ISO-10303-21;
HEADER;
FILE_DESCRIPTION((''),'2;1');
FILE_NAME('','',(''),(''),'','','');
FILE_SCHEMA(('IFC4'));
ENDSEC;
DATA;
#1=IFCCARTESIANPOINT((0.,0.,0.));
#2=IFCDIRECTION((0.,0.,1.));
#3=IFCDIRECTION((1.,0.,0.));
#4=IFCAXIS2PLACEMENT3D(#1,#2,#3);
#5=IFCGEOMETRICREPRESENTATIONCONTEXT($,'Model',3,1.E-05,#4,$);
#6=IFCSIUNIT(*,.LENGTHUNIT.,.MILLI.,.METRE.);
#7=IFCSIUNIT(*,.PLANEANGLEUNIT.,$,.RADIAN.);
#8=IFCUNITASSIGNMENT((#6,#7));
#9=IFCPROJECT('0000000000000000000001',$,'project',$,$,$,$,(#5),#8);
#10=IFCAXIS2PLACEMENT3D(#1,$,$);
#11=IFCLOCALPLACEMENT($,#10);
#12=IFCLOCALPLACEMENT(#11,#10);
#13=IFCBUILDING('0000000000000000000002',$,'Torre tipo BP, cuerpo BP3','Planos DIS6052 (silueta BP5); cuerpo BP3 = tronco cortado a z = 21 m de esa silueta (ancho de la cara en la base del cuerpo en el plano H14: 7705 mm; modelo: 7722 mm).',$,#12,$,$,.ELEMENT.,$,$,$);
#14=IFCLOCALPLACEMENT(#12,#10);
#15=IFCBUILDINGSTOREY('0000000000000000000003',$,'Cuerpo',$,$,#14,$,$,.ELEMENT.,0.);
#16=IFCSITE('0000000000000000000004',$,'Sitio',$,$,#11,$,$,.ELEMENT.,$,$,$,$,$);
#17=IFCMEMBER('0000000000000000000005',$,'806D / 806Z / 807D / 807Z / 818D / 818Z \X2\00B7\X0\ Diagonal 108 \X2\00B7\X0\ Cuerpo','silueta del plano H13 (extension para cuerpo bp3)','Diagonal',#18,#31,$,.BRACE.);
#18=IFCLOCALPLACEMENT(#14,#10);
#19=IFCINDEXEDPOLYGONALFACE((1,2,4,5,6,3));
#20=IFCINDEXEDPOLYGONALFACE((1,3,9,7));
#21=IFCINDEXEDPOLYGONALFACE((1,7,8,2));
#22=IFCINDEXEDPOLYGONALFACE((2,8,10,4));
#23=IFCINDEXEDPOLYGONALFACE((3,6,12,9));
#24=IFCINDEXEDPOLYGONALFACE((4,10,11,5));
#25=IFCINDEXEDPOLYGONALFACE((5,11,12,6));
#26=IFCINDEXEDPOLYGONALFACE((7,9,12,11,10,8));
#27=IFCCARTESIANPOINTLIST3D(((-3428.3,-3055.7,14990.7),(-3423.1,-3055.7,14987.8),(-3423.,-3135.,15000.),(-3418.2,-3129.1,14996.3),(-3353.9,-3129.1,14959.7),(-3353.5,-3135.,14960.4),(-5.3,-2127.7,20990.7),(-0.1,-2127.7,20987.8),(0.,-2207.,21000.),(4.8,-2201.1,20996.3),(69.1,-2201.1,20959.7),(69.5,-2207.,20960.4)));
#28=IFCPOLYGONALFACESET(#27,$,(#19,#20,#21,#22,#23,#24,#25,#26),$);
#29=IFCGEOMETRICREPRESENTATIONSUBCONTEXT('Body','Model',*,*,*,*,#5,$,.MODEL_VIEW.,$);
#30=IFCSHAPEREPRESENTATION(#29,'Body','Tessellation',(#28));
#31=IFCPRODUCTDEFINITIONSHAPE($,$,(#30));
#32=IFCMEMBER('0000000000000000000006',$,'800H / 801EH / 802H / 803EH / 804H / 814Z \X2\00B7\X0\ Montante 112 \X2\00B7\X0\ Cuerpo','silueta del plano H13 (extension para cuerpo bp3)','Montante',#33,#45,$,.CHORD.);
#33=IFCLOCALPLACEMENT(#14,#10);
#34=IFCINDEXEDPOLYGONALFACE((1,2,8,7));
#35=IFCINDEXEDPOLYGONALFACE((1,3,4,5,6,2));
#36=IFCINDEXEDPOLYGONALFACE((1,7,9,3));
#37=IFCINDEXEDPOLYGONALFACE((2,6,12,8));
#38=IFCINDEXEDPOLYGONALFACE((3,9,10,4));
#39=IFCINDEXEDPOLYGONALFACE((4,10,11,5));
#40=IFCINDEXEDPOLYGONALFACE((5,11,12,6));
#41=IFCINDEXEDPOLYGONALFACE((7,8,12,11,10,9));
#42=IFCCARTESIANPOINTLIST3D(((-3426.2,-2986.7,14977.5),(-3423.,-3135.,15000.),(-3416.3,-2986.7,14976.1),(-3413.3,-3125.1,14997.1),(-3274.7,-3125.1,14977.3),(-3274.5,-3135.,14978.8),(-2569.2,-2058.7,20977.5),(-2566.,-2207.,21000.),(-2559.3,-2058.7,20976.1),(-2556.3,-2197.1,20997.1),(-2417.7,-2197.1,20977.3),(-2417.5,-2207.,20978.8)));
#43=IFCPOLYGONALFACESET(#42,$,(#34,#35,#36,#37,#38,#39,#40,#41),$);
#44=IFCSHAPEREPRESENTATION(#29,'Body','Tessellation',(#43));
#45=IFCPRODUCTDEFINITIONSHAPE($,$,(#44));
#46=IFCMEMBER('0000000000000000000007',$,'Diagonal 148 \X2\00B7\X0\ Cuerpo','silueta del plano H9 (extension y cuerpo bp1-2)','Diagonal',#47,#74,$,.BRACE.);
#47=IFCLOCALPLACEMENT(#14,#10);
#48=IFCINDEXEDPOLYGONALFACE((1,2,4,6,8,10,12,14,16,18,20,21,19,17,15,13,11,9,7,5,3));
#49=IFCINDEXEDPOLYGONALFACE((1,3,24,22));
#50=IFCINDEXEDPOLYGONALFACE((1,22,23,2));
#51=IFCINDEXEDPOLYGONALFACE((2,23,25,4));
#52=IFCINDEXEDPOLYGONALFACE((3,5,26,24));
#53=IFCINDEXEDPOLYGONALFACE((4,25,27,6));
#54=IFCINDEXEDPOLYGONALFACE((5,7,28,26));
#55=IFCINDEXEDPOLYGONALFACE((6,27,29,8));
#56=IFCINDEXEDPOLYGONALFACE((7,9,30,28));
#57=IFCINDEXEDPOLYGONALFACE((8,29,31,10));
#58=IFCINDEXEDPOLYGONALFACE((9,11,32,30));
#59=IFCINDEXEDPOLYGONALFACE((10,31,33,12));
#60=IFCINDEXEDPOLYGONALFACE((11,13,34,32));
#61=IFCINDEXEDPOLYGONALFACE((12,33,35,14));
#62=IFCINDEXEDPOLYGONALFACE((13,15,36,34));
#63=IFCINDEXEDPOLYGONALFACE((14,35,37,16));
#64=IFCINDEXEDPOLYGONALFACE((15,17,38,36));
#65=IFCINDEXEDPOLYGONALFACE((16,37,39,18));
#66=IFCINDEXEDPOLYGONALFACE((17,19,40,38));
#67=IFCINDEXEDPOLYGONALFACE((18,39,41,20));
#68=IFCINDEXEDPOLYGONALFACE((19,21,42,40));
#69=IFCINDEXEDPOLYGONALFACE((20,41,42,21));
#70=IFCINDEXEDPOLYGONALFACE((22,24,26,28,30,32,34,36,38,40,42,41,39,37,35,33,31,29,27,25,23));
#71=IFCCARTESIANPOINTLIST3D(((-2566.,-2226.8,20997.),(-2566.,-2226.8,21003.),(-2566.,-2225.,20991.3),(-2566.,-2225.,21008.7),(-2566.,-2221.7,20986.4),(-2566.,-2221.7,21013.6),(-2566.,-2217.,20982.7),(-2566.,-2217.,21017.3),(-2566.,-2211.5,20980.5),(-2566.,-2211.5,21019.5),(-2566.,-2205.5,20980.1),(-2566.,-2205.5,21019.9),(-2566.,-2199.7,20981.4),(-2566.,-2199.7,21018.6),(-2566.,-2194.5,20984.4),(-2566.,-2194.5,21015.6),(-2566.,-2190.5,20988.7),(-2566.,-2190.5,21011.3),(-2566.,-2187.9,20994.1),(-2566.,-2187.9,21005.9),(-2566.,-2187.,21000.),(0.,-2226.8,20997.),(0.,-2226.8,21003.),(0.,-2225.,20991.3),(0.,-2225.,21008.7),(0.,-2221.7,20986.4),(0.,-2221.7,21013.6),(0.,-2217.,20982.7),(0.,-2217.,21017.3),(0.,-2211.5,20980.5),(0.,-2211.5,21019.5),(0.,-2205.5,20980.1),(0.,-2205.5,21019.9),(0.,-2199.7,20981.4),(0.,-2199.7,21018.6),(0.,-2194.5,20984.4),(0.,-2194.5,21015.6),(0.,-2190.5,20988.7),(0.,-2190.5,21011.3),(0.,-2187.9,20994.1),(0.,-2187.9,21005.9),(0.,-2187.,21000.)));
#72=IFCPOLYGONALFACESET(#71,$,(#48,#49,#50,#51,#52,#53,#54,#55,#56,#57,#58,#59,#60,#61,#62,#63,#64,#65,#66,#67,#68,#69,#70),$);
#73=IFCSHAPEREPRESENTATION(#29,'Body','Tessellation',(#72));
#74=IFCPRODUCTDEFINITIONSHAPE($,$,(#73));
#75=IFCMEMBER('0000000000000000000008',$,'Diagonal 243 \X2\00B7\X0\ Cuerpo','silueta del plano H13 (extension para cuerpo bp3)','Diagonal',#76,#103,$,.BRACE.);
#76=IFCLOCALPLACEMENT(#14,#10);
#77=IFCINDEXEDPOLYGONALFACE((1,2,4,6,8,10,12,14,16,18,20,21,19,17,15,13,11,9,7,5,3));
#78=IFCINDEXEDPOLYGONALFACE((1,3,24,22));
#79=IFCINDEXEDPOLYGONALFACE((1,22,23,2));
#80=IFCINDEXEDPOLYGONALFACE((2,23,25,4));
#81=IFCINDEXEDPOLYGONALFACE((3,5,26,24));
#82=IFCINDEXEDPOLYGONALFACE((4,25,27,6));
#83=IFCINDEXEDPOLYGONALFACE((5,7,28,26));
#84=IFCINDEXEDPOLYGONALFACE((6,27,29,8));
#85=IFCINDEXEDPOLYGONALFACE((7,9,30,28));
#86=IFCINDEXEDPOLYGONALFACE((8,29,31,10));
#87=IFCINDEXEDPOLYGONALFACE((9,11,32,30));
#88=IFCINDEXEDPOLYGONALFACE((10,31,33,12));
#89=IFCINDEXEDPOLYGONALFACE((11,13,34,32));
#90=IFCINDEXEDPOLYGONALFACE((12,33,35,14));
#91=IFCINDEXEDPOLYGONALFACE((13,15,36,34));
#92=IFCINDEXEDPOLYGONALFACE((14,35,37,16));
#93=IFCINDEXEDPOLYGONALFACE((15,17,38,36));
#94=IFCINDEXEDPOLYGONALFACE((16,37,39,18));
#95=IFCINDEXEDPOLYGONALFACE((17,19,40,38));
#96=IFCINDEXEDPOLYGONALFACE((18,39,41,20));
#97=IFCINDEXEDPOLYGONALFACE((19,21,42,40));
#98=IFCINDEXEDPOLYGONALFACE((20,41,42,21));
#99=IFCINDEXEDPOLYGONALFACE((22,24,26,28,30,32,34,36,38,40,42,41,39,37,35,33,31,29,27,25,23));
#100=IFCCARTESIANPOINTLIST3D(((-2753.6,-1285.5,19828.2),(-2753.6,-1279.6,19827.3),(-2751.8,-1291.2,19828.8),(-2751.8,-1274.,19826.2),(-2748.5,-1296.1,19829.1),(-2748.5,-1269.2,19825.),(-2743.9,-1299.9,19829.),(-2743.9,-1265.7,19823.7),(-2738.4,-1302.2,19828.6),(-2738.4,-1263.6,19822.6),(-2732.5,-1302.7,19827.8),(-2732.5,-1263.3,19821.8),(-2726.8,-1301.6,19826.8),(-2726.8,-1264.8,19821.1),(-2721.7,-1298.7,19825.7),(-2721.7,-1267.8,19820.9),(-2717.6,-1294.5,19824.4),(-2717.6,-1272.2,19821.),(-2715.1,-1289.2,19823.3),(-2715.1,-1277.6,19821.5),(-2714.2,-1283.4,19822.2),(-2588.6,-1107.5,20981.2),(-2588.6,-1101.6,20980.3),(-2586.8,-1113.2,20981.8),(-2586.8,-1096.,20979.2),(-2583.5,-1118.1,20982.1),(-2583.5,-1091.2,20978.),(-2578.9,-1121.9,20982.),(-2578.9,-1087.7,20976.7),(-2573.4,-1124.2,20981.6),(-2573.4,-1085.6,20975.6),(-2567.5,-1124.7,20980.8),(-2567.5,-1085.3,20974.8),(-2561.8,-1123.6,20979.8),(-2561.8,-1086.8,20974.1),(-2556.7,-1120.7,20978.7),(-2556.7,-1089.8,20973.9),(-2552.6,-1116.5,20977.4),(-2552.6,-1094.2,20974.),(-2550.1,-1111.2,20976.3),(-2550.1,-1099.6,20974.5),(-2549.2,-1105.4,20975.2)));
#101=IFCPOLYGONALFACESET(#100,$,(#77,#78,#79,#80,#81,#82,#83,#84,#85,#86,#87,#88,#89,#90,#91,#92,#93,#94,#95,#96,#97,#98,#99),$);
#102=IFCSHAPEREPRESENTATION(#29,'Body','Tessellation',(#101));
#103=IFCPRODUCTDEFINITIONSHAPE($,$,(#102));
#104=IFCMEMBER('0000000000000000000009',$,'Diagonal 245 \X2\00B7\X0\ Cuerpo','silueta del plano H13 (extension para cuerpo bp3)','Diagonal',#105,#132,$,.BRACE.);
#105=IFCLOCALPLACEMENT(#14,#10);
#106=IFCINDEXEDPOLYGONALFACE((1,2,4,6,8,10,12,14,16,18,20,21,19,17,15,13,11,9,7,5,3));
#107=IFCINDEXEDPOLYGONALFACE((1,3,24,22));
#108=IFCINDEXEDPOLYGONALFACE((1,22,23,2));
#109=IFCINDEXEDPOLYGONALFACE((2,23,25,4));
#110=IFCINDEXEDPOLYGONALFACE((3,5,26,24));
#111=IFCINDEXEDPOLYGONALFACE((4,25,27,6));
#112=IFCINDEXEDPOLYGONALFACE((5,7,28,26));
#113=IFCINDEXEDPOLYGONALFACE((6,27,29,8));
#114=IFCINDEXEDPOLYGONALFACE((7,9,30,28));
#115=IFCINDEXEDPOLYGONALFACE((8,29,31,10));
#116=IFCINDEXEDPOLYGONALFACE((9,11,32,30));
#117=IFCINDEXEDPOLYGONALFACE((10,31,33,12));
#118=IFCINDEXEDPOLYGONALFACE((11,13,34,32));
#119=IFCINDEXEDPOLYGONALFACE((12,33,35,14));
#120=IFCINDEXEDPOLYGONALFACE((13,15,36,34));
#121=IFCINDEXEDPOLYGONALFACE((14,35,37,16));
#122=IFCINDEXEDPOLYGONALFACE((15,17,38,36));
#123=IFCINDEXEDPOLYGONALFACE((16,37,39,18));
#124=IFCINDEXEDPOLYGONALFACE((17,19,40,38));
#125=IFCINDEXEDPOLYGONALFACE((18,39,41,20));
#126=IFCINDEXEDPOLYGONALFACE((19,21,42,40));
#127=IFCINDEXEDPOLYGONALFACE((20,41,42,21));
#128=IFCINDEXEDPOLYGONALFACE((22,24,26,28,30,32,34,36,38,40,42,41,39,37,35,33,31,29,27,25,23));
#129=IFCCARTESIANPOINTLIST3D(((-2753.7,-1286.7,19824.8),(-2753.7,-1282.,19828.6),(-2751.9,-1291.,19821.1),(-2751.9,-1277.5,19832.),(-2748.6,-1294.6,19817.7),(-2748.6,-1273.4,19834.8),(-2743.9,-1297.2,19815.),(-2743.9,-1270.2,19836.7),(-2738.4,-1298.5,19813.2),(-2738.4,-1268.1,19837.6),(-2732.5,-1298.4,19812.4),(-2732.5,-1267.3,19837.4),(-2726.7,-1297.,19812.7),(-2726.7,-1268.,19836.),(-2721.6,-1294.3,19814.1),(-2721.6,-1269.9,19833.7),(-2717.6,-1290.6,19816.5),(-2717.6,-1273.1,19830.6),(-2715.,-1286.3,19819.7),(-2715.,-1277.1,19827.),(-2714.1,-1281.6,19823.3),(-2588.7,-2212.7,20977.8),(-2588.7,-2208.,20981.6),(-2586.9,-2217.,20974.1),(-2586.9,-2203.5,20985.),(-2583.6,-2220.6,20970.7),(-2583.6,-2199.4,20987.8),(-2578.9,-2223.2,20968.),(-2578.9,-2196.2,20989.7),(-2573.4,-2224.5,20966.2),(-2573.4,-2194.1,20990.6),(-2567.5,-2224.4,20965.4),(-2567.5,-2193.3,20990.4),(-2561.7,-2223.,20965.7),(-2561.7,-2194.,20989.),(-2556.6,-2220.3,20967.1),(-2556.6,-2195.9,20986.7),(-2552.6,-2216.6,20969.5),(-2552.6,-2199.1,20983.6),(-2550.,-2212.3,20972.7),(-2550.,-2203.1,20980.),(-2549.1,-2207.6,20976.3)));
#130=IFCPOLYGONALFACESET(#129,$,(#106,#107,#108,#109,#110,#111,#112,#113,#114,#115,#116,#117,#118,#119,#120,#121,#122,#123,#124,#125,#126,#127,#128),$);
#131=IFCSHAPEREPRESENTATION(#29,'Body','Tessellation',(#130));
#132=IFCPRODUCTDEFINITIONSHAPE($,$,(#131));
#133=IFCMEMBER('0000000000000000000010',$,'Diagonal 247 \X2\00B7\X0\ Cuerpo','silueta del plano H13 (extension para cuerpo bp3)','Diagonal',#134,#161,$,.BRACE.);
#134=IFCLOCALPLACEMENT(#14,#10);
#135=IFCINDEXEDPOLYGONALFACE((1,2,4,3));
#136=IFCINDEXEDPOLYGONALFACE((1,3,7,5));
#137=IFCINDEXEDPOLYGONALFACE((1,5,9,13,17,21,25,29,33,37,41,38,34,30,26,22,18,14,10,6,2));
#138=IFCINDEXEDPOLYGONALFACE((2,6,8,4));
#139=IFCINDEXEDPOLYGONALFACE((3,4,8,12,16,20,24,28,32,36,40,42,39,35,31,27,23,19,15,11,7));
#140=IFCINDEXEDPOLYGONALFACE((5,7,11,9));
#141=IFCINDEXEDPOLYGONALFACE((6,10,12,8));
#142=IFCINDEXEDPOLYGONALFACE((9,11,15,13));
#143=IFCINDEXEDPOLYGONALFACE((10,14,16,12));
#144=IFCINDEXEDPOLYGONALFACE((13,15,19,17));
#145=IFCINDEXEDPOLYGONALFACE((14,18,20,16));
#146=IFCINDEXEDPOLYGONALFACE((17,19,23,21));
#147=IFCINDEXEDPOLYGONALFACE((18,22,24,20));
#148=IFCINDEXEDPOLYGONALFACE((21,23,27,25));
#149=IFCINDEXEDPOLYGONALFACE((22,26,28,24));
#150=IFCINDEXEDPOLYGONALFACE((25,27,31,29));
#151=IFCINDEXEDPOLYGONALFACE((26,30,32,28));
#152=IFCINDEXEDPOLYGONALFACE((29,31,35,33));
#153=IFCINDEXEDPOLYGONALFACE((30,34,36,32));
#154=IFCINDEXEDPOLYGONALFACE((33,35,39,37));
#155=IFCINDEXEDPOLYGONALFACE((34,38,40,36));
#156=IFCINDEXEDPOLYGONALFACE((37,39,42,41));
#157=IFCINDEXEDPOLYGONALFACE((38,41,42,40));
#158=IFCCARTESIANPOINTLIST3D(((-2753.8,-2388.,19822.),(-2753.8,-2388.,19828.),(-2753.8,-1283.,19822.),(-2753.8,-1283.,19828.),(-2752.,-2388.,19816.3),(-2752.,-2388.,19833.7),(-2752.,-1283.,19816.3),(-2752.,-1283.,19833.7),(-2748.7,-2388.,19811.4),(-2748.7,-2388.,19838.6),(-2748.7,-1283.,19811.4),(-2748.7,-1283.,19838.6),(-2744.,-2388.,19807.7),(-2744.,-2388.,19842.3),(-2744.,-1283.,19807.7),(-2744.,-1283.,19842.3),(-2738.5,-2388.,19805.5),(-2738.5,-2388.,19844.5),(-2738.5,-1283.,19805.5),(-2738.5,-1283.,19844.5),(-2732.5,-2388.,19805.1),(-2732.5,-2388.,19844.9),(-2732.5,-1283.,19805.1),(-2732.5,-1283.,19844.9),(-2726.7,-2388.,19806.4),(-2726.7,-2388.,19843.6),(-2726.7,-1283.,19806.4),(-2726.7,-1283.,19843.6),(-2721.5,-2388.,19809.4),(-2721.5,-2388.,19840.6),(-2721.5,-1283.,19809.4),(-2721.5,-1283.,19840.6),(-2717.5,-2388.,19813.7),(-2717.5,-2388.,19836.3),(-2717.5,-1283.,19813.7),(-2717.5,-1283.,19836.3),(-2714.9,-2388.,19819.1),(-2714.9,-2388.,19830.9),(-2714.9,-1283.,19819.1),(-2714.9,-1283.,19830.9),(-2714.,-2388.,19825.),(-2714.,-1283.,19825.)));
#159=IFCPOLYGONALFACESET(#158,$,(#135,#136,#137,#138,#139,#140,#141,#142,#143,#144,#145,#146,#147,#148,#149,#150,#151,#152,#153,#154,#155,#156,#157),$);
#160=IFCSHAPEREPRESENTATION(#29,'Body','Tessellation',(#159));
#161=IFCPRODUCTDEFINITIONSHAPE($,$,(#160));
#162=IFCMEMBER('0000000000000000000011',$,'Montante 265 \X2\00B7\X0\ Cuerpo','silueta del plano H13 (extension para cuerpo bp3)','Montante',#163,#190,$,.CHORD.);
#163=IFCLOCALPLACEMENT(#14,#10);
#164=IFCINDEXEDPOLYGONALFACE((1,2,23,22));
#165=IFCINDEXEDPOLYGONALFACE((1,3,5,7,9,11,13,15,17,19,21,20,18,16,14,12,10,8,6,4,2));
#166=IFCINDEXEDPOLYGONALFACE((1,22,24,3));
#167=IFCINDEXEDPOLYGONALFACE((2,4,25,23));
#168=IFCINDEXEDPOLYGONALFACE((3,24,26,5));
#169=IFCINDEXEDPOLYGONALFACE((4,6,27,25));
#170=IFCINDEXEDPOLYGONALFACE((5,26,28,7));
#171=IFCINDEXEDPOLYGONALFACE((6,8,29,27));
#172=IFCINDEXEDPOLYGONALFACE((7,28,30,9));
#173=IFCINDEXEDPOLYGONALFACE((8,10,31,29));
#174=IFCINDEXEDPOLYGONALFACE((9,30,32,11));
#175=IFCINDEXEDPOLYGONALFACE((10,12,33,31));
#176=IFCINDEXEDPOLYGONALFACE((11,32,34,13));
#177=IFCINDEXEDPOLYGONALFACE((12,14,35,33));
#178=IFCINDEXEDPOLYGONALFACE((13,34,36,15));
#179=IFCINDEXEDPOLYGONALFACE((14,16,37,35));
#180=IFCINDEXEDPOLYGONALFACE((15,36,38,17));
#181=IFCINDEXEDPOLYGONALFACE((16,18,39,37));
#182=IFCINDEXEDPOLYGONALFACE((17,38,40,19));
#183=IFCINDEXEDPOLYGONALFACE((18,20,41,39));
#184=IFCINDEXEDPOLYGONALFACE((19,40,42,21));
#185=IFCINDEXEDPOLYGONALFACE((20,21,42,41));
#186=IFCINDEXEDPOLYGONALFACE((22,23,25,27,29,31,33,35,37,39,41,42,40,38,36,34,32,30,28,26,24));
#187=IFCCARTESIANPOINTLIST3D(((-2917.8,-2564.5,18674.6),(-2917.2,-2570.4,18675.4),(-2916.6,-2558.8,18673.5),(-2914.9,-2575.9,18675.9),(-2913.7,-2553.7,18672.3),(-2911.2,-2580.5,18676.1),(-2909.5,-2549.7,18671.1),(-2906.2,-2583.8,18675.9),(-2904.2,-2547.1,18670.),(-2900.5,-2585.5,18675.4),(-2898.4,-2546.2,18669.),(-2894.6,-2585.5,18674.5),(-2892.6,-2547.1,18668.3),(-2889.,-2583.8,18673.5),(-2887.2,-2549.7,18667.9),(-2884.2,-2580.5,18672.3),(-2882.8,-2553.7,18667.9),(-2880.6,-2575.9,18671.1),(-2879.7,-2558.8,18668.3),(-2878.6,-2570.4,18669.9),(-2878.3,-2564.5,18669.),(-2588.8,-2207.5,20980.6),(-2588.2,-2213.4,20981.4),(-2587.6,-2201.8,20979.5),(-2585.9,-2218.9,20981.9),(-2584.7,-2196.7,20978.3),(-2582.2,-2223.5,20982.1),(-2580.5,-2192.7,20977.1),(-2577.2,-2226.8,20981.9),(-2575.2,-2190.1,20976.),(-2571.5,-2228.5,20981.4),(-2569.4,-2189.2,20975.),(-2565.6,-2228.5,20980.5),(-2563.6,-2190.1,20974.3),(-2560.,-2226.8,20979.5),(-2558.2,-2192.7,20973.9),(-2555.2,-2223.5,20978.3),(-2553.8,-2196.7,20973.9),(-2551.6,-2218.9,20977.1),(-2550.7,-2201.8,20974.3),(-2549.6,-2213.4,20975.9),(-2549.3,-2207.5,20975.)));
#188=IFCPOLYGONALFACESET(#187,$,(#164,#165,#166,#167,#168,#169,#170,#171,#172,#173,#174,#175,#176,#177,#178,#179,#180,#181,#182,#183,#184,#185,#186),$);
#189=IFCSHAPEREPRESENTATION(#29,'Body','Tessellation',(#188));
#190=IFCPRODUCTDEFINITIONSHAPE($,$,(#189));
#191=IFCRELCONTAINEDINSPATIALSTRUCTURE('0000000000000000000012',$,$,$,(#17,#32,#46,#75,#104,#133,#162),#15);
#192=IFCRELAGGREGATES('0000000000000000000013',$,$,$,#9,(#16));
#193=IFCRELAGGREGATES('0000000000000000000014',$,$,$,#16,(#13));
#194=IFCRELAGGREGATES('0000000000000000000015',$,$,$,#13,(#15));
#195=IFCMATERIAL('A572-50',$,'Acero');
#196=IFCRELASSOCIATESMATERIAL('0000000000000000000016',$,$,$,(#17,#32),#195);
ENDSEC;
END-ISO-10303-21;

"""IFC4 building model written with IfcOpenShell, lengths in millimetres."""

from ifc_helpers import new_model, si_unit, frame, frame_2d, origin, origin_with_axes, place, context, subcontext, project, spatial, circle, l_section, extrude, material, element, save


model = new_model("IFC4")

# Units and contexts
model_context = context("Model", 3, precision=1e-05, world=origin_with_axes())
body_context = subcontext(model_context, "Body", "Model", "MODEL_VIEW")
ifc_project = project(units=[si_unit("LENGTHUNIT", "METRE", prefix="MILLI"), si_unit("PLANEANGLEUNIT", "RADIAN")], contexts=[model_context])

# Site, building, storey
site_placement = place(None, origin())
site = spatial("IfcSite", under=ifc_project, at=site_placement, Name="Sitio", CompositionType="ELEMENT")
building_placement = place(site_placement, origin())
building = spatial("IfcBuilding", under=site, at=building_placement, Name="Torre tipo BP, cuerpo BP3", Description="Planos DIS6052 (silueta BP5); cuerpo BP3 = tronco cortado a z = 21 m de esa silueta (ancho de la cara en la base del cuerpo en el plano H14: 7705 mm; modelo: 7722 mm).", CompositionType="ELEMENT")
storey_placement = place(building_placement, origin())
storey = spatial("IfcBuildingStorey", under=building, at=storey_placement, Name="Cuerpo", CompositionType="ELEMENT", Elevation=0.0)

# Members
ifc_material_1 = material(Name="A572-50", Category="Acero")
member_1_placement = place(storey_placement, frame((0.0, -2207.0, 21000.0), z_axis=(-0.491119, -0.133146, -0.860857), x_axis=(-0.065978, 0.991096, -0.115649)))
element("IfcMember", 1, at=member_1_placement, inside=storey, material=ifc_material_1, Name="806D / 806Z / 807D / 807Z / 818D / 818Z · Diagonal 108 · Cuerpo", Description="silueta del plano H13 (extension para cuerpo bp3)", ObjectType="Diagonal", PredefinedType="BRACE", context=body_context, shape_type="SweptSolid", body=[
    extrude(l_section(Depth=80.0, Width=80.0, Thickness=6.0, at=frame_2d((40.0, 40.0))), None, (0.0, 0.0, 1.0), 6969.8),
])
member_2_placement = place(storey_placement, frame((-2566.0, -2207.0, 21000.0), z_axis=(-0.139769, -0.151349, -0.978549), x_axis=(-0.0214, 0.98848, -0.149828)))
element("IfcMember", 2, at=member_2_placement, inside=storey, material=ifc_material_1, Name="800H / 801EH / 802H / 803EH / 804H / 814Z · Montante 112 · Cuerpo", Description="silueta del plano H13 (extension para cuerpo bp3)", ObjectType="Montante", PredefinedType="CHORD", context=body_context, shape_type="SweptSolid", body=[
    extrude(l_section(Depth=150.0, Width=150.0, Thickness=10.0, at=frame_2d((75.0, 75.0))), None, (0.0, 0.0, 1.0), 6131.5),
])
member_3_placement = place(storey_placement, frame((-2566.0, -2207.0, 21000.0), z_axis=(1.0, 0.0, 0.0), x_axis=(0.0, 1.0, 0.0)))
element("IfcMember", 3, at=member_3_placement, inside=storey, Name="Diagonal 148 · Cuerpo", Description="silueta del plano H9 (extension y cuerpo bp1-2)", ObjectType="Diagonal", PredefinedType="BRACE", context=body_context, shape_type="SweptSolid", body=[
    extrude(circle(Radius=20.0), None, (0.0, 0.0, 1.0), 2566.0),
])
member_4_placement = place(storey_placement, frame((-2569.0, -1105.0, 20978.0), z_axis=(-0.140036, -0.151069, -0.978554), x_axis=(0.990146, -0.021366, -0.138396)))
element("IfcMember", 4, at=member_4_placement, inside=storey, Name="Diagonal 243 · Cuerpo", Description="silueta del plano H13 (extension para cuerpo bp3)", ObjectType="Diagonal", PredefinedType="BRACE", context=body_context, shape_type="SweptSolid", body=[
    extrude(circle(Radius=20.0), None, (0.0, 0.0, 1.0), 1178.3),
])
member_5_placement = place(storey_placement, frame((-2734.0, -1283.0, 19825.0), z_axis=(0.110888, -0.622317, 0.774872), x_axis=(0.993833, 0.069436, -0.086457)))
element("IfcMember", 5, at=member_5_placement, inside=storey, Name="Diagonal 245 · Cuerpo", Description="silueta del plano H13 (extension para cuerpo bp3)", ObjectType="Diagonal", PredefinedType="BRACE", context=body_context, shape_type="SweptSolid", body=[
    extrude(circle(Radius=20.0), None, (0.0, 0.0, 1.0), 1488.0),
])
member_6_placement = place(storey_placement, frame((-2734.0, -1283.0, 19825.0), z_axis=(0.0, -1.0, 0.0), x_axis=(1.0, 0.0, 0.0)))
element("IfcMember", 6, at=member_6_placement, inside=storey, Name="Diagonal 247 · Cuerpo", Description="silueta del plano H13 (extension para cuerpo bp3)", ObjectType="Diagonal", PredefinedType="BRACE", context=body_context, shape_type="SweptSolid", body=[
    extrude(circle(Radius=20.0), None, (0.0, 0.0, 1.0), 1105.0),
])
member_7_placement = place(storey_placement, frame((-2569.0, -2209.0, 20978.0), z_axis=(-0.139611, -0.151493, -0.978549), x_axis=(-0.021397, 0.988458, -0.149974)))
element("IfcMember", 7, at=member_7_placement, inside=storey, Name="Montante 265 · Cuerpo", Description="silueta del plano H13 (extension para cuerpo bp3)", ObjectType="Montante", PredefinedType="CHORD", context=body_context, shape_type="SweptSolid", body=[
    extrude(circle(Radius=20.0), None, (0.0, 0.0, 1.0), 2356.5),
])

save(model, "model.ifc")
